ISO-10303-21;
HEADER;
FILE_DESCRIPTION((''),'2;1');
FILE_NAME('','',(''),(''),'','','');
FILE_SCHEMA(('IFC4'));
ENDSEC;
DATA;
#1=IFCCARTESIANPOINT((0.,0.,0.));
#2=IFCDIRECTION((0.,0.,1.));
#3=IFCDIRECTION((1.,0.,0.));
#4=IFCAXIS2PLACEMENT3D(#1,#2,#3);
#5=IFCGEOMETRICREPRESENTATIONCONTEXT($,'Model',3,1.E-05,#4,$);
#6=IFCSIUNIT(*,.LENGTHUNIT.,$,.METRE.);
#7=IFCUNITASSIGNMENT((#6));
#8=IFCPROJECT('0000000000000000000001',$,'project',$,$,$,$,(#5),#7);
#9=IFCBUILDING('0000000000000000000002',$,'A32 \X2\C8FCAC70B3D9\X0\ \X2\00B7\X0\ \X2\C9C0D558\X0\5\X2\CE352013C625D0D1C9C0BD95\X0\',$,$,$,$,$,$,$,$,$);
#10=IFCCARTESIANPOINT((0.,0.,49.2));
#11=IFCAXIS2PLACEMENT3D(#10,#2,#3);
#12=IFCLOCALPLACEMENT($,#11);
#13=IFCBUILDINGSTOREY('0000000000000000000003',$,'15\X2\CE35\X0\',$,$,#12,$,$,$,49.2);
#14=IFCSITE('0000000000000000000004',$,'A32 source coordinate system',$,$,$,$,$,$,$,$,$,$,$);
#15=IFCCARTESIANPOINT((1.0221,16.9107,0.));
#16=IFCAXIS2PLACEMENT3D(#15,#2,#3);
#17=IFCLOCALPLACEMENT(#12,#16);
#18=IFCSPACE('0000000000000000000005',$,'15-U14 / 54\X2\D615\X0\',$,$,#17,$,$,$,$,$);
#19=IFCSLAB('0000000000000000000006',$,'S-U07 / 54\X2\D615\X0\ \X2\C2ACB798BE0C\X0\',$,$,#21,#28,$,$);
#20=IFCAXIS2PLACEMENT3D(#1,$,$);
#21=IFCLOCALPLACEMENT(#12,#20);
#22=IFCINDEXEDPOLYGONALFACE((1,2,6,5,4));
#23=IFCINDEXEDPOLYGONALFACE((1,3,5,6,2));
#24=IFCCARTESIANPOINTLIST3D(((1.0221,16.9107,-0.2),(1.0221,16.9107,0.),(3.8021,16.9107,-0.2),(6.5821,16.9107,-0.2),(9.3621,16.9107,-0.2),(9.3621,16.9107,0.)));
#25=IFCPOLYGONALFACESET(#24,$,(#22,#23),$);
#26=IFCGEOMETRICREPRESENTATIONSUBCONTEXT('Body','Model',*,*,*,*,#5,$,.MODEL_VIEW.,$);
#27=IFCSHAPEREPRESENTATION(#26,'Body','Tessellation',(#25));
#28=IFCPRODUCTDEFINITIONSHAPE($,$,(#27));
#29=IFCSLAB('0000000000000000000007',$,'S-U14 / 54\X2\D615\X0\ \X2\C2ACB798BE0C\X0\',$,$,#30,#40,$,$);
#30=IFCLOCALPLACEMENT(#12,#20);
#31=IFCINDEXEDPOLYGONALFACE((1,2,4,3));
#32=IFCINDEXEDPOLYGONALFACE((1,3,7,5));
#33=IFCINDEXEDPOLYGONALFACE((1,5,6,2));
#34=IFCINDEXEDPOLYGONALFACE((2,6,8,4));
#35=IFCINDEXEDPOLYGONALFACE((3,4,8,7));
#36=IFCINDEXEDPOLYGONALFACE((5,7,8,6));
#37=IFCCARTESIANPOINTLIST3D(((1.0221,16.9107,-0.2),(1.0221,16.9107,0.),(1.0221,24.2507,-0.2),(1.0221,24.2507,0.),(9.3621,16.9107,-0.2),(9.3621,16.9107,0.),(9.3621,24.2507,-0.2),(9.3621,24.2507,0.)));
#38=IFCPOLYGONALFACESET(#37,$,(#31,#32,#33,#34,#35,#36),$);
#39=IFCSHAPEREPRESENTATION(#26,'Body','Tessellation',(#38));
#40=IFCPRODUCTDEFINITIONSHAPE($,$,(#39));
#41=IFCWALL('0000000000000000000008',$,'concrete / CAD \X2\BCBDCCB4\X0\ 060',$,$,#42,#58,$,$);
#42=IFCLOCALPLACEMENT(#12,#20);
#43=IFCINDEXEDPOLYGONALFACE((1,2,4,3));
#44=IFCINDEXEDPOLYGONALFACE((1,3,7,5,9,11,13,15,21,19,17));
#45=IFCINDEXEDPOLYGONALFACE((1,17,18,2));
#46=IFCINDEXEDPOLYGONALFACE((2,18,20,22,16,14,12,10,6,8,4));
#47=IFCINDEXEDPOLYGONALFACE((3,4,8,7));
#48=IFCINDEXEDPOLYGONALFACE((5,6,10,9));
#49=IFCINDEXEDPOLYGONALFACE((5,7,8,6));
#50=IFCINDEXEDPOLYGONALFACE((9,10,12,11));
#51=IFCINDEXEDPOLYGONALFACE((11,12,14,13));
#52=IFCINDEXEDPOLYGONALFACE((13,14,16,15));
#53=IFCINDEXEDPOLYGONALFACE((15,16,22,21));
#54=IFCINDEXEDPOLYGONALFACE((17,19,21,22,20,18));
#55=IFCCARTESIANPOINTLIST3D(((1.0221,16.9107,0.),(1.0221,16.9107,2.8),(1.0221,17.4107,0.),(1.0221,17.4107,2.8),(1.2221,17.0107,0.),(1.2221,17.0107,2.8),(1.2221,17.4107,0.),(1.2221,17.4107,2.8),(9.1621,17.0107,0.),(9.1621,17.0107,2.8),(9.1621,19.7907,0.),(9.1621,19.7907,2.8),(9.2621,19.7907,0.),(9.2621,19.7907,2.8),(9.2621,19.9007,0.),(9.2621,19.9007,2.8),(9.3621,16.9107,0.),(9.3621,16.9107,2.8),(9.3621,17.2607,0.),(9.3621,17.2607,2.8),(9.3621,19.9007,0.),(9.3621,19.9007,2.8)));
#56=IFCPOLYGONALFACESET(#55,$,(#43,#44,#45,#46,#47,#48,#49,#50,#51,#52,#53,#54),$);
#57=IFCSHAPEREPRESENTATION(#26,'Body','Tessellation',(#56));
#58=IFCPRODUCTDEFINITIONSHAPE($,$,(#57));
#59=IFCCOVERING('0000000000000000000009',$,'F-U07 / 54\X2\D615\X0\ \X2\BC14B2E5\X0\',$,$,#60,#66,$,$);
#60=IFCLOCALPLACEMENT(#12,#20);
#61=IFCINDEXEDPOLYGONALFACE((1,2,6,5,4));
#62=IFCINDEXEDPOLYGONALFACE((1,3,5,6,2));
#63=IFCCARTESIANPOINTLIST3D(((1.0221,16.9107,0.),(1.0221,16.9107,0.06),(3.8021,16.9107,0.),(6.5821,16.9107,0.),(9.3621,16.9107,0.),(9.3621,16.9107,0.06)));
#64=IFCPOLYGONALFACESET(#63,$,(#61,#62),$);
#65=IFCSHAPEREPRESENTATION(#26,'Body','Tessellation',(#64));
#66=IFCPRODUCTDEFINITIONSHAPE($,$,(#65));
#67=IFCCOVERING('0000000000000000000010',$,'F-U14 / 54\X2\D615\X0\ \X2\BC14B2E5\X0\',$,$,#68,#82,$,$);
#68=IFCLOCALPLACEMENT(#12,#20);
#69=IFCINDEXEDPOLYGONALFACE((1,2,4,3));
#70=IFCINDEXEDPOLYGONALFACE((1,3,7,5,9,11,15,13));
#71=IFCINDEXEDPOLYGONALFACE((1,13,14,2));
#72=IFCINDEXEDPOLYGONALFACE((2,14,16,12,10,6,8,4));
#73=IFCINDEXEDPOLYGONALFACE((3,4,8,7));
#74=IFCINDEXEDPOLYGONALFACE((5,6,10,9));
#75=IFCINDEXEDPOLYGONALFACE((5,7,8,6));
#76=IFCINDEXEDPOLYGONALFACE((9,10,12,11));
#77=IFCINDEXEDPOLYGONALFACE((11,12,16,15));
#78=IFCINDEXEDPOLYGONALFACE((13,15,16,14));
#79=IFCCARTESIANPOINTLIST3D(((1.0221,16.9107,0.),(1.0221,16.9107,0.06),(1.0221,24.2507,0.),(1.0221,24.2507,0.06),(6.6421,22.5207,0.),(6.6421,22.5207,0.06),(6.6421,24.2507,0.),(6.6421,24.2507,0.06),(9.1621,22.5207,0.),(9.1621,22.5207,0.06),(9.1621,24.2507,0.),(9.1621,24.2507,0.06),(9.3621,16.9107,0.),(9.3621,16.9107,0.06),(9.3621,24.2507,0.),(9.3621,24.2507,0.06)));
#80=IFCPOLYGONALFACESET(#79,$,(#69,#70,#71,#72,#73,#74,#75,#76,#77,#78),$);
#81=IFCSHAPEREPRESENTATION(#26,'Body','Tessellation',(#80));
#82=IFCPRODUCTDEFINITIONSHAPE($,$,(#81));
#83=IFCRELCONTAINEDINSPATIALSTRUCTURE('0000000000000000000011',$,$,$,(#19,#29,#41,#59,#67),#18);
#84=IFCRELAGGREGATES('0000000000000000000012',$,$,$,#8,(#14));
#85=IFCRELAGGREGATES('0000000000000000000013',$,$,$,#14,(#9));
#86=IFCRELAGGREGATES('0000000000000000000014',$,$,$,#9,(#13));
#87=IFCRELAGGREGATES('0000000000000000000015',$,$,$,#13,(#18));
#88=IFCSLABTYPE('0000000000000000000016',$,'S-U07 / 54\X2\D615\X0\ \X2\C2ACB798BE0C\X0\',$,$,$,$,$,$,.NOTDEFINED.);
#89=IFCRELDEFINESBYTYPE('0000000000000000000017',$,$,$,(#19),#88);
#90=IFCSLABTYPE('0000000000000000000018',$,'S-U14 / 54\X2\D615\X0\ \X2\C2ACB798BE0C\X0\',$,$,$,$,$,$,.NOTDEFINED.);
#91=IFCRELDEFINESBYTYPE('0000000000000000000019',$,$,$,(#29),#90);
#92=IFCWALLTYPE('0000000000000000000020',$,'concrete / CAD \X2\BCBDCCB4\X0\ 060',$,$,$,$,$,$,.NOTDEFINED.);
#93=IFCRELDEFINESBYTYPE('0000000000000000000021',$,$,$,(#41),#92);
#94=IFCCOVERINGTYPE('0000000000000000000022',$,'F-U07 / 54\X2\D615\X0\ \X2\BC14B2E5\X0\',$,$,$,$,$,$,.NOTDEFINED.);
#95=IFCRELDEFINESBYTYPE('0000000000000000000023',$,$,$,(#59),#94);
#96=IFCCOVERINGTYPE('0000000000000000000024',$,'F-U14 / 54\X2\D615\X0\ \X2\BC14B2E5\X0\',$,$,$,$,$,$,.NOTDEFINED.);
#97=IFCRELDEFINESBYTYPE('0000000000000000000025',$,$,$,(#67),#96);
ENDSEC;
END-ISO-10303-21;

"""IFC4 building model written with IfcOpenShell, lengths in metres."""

from ifc_helpers import new_model, si_unit, frame, origin, origin_with_axes, place, context, subcontext, project, spatial, polyline, outline, extrude, source, transform, mapped, type_object, type_shapes, element, save


model = new_model("IFC4")

# Units and contexts
model_context = context("Model", 3, precision=1e-05, world=origin_with_axes())
body_context = subcontext(model_context, "Body", "Model", "MODEL_VIEW")
ifc_project = project(units=[si_unit("LENGTHUNIT", "METRE")], contexts=[model_context])

# Site, building, storey, space
storey_placement = place(None, frame((0.0, 0.0, 49.2), z_axis=(0.0, 0.0, 1.0), x_axis=(1.0, 0.0, 0.0)))
space_1_placement = place(storey_placement, frame((1.0221, 16.9107, 0.0), z_axis=(0.0, 0.0, 1.0), x_axis=(1.0, 0.0, 0.0)))
site = spatial("IfcSite", under=ifc_project, Name="A32 source coordinate system")
building = spatial("IfcBuilding", under=site, Name="A32 주거동 · 지하5층–옥탑지붕")
storey = spatial("IfcBuildingStorey", under=building, at=storey_placement, Name="15층", Elevation=49.2)
space_1 = spatial("IfcSpace", under=storey, at=space_1_placement, Name="15-U14 / 54형")

# Slabs
slab_type_1 = type_object("IfcSlabType", Name="S-U07 / 54형 슬래브", PredefinedType="NOTDEFINED")
shared_shape_1 = source(origin(), body_context, "Body", "SweptSolid", [
    extrude(outline(polyline([(0.0, 0.0), (0.0, 0.0), (8.34, 0.0), (8.34, 0.0), (0.0, 0.0)])), frame((0.0, 0.0, -0.2)), (0.0, 0.0, 1.0), 0.2),
])
type_shapes(slab_type_1, [shared_shape_1])
slab_1_placement = place(space_1_placement, origin_with_axes())
element("IfcSlab", 1, at=slab_1_placement, inside=space_1, type_object=slab_type_1, Name="S-U07 / 54형 슬래브", context=body_context, shape_type="MappedRepresentation", body=[
    mapped(shared_shape_1, transform((0.0, 0.0, 0.0), scale=1.0)),
])
slab_type_2 = type_object("IfcSlabType", Name="S-U14 / 54형 슬래브", PredefinedType="NOTDEFINED")
shared_shape_2 = source(origin(), body_context, "Body", "SweptSolid", [
    extrude(outline(polyline([(0.0, 0.0), (0.0, 7.34), (8.34, 7.34), (8.34, 0.0), (0.0, 0.0)])), frame((0.0, 0.0, -0.2)), (0.0, 0.0, 1.0), 0.2),
])
type_shapes(slab_type_2, [shared_shape_2])
slab_2_placement = place(space_1_placement, origin_with_axes())
element("IfcSlab", 2, at=slab_2_placement, inside=space_1, type_object=slab_type_2, Name="S-U14 / 54형 슬래브", context=body_context, shape_type="MappedRepresentation", body=[
    mapped(shared_shape_2, transform((0.0, 0.0, 0.0), scale=1.0)),
])

# Wall
wall_type_1 = type_object("IfcWallType", Name="concrete / CAD 벽체 060", PredefinedType="NOTDEFINED")
shared_shape_3 = source(origin(), body_context, "Body", "SweptSolid", [
    extrude(outline(polyline([(0.2, 0.5), (0.2, 0.1), (8.14, 0.1), (8.14, 2.88), (8.24, 2.88), (8.24, 2.99), (8.34, 2.99), (8.34, 0.35), (8.34, 0.35), (8.34, 0.0), (0.0, 0.0), (0.0, 0.5), (0.2, 0.5)])), origin(), (0.0, 0.0, 1.0), 2.8),
])
type_shapes(wall_type_1, [shared_shape_3])
wall_1_placement = place(space_1_placement, origin_with_axes())
element("IfcWall", 3, at=wall_1_placement, inside=space_1, type_object=wall_type_1, Name="concrete / CAD 벽체 060", context=body_context, shape_type="MappedRepresentation", body=[
    mapped(shared_shape_3, transform((0.0, 0.0, 0.0), scale=1.0)),
])

# Coverings
covering_type_1 = type_object("IfcCoveringType", Name="F-U07 / 54형 바닥", PredefinedType="NOTDEFINED")
shared_shape_4 = source(origin(), body_context, "Body", "SweptSolid", [
    extrude(outline(polyline([(0.0, 0.0), (0.0, 0.0), (8.34, 0.0), (8.34, 0.0), (0.0, 0.0)])), origin(), (0.0, 0.0, 1.0), 0.06),
])
type_shapes(covering_type_1, [shared_shape_4])
covering_1_placement = place(space_1_placement, origin_with_axes())
element("IfcCovering", 4, at=covering_1_placement, inside=space_1, type_object=covering_type_1, Name="F-U07 / 54형 바닥", context=body_context, shape_type="MappedRepresentation", body=[
    mapped(shared_shape_4, transform((0.0, 0.0, 0.0), scale=1.0)),
])
covering_type_2 = type_object("IfcCoveringType", Name="F-U14 / 54형 바닥", PredefinedType="NOTDEFINED")
shared_shape_5 = source(origin(), body_context, "Body", "SweptSolid", [
    extrude(outline(polyline([(8.14, 7.34), (8.34, 7.34), (8.34, 0.0), (0.0, 0.0), (0.0, 7.34), (5.62, 7.34), (5.62, 5.61), (8.14, 5.61), (8.14, 7.34)])), origin(), (0.0, 0.0, 1.0), 0.06),
])
type_shapes(covering_type_2, [shared_shape_5])
covering_2_placement = place(space_1_placement, origin_with_axes())
element("IfcCovering", 5, at=covering_2_placement, inside=space_1, type_object=covering_type_2, Name="F-U14 / 54형 바닥", context=body_context, shape_type="MappedRepresentation", body=[
    mapped(shared_shape_5, transform((0.0, 0.0, 0.0), scale=1.0)),
])

save(model, "model.ifc")
